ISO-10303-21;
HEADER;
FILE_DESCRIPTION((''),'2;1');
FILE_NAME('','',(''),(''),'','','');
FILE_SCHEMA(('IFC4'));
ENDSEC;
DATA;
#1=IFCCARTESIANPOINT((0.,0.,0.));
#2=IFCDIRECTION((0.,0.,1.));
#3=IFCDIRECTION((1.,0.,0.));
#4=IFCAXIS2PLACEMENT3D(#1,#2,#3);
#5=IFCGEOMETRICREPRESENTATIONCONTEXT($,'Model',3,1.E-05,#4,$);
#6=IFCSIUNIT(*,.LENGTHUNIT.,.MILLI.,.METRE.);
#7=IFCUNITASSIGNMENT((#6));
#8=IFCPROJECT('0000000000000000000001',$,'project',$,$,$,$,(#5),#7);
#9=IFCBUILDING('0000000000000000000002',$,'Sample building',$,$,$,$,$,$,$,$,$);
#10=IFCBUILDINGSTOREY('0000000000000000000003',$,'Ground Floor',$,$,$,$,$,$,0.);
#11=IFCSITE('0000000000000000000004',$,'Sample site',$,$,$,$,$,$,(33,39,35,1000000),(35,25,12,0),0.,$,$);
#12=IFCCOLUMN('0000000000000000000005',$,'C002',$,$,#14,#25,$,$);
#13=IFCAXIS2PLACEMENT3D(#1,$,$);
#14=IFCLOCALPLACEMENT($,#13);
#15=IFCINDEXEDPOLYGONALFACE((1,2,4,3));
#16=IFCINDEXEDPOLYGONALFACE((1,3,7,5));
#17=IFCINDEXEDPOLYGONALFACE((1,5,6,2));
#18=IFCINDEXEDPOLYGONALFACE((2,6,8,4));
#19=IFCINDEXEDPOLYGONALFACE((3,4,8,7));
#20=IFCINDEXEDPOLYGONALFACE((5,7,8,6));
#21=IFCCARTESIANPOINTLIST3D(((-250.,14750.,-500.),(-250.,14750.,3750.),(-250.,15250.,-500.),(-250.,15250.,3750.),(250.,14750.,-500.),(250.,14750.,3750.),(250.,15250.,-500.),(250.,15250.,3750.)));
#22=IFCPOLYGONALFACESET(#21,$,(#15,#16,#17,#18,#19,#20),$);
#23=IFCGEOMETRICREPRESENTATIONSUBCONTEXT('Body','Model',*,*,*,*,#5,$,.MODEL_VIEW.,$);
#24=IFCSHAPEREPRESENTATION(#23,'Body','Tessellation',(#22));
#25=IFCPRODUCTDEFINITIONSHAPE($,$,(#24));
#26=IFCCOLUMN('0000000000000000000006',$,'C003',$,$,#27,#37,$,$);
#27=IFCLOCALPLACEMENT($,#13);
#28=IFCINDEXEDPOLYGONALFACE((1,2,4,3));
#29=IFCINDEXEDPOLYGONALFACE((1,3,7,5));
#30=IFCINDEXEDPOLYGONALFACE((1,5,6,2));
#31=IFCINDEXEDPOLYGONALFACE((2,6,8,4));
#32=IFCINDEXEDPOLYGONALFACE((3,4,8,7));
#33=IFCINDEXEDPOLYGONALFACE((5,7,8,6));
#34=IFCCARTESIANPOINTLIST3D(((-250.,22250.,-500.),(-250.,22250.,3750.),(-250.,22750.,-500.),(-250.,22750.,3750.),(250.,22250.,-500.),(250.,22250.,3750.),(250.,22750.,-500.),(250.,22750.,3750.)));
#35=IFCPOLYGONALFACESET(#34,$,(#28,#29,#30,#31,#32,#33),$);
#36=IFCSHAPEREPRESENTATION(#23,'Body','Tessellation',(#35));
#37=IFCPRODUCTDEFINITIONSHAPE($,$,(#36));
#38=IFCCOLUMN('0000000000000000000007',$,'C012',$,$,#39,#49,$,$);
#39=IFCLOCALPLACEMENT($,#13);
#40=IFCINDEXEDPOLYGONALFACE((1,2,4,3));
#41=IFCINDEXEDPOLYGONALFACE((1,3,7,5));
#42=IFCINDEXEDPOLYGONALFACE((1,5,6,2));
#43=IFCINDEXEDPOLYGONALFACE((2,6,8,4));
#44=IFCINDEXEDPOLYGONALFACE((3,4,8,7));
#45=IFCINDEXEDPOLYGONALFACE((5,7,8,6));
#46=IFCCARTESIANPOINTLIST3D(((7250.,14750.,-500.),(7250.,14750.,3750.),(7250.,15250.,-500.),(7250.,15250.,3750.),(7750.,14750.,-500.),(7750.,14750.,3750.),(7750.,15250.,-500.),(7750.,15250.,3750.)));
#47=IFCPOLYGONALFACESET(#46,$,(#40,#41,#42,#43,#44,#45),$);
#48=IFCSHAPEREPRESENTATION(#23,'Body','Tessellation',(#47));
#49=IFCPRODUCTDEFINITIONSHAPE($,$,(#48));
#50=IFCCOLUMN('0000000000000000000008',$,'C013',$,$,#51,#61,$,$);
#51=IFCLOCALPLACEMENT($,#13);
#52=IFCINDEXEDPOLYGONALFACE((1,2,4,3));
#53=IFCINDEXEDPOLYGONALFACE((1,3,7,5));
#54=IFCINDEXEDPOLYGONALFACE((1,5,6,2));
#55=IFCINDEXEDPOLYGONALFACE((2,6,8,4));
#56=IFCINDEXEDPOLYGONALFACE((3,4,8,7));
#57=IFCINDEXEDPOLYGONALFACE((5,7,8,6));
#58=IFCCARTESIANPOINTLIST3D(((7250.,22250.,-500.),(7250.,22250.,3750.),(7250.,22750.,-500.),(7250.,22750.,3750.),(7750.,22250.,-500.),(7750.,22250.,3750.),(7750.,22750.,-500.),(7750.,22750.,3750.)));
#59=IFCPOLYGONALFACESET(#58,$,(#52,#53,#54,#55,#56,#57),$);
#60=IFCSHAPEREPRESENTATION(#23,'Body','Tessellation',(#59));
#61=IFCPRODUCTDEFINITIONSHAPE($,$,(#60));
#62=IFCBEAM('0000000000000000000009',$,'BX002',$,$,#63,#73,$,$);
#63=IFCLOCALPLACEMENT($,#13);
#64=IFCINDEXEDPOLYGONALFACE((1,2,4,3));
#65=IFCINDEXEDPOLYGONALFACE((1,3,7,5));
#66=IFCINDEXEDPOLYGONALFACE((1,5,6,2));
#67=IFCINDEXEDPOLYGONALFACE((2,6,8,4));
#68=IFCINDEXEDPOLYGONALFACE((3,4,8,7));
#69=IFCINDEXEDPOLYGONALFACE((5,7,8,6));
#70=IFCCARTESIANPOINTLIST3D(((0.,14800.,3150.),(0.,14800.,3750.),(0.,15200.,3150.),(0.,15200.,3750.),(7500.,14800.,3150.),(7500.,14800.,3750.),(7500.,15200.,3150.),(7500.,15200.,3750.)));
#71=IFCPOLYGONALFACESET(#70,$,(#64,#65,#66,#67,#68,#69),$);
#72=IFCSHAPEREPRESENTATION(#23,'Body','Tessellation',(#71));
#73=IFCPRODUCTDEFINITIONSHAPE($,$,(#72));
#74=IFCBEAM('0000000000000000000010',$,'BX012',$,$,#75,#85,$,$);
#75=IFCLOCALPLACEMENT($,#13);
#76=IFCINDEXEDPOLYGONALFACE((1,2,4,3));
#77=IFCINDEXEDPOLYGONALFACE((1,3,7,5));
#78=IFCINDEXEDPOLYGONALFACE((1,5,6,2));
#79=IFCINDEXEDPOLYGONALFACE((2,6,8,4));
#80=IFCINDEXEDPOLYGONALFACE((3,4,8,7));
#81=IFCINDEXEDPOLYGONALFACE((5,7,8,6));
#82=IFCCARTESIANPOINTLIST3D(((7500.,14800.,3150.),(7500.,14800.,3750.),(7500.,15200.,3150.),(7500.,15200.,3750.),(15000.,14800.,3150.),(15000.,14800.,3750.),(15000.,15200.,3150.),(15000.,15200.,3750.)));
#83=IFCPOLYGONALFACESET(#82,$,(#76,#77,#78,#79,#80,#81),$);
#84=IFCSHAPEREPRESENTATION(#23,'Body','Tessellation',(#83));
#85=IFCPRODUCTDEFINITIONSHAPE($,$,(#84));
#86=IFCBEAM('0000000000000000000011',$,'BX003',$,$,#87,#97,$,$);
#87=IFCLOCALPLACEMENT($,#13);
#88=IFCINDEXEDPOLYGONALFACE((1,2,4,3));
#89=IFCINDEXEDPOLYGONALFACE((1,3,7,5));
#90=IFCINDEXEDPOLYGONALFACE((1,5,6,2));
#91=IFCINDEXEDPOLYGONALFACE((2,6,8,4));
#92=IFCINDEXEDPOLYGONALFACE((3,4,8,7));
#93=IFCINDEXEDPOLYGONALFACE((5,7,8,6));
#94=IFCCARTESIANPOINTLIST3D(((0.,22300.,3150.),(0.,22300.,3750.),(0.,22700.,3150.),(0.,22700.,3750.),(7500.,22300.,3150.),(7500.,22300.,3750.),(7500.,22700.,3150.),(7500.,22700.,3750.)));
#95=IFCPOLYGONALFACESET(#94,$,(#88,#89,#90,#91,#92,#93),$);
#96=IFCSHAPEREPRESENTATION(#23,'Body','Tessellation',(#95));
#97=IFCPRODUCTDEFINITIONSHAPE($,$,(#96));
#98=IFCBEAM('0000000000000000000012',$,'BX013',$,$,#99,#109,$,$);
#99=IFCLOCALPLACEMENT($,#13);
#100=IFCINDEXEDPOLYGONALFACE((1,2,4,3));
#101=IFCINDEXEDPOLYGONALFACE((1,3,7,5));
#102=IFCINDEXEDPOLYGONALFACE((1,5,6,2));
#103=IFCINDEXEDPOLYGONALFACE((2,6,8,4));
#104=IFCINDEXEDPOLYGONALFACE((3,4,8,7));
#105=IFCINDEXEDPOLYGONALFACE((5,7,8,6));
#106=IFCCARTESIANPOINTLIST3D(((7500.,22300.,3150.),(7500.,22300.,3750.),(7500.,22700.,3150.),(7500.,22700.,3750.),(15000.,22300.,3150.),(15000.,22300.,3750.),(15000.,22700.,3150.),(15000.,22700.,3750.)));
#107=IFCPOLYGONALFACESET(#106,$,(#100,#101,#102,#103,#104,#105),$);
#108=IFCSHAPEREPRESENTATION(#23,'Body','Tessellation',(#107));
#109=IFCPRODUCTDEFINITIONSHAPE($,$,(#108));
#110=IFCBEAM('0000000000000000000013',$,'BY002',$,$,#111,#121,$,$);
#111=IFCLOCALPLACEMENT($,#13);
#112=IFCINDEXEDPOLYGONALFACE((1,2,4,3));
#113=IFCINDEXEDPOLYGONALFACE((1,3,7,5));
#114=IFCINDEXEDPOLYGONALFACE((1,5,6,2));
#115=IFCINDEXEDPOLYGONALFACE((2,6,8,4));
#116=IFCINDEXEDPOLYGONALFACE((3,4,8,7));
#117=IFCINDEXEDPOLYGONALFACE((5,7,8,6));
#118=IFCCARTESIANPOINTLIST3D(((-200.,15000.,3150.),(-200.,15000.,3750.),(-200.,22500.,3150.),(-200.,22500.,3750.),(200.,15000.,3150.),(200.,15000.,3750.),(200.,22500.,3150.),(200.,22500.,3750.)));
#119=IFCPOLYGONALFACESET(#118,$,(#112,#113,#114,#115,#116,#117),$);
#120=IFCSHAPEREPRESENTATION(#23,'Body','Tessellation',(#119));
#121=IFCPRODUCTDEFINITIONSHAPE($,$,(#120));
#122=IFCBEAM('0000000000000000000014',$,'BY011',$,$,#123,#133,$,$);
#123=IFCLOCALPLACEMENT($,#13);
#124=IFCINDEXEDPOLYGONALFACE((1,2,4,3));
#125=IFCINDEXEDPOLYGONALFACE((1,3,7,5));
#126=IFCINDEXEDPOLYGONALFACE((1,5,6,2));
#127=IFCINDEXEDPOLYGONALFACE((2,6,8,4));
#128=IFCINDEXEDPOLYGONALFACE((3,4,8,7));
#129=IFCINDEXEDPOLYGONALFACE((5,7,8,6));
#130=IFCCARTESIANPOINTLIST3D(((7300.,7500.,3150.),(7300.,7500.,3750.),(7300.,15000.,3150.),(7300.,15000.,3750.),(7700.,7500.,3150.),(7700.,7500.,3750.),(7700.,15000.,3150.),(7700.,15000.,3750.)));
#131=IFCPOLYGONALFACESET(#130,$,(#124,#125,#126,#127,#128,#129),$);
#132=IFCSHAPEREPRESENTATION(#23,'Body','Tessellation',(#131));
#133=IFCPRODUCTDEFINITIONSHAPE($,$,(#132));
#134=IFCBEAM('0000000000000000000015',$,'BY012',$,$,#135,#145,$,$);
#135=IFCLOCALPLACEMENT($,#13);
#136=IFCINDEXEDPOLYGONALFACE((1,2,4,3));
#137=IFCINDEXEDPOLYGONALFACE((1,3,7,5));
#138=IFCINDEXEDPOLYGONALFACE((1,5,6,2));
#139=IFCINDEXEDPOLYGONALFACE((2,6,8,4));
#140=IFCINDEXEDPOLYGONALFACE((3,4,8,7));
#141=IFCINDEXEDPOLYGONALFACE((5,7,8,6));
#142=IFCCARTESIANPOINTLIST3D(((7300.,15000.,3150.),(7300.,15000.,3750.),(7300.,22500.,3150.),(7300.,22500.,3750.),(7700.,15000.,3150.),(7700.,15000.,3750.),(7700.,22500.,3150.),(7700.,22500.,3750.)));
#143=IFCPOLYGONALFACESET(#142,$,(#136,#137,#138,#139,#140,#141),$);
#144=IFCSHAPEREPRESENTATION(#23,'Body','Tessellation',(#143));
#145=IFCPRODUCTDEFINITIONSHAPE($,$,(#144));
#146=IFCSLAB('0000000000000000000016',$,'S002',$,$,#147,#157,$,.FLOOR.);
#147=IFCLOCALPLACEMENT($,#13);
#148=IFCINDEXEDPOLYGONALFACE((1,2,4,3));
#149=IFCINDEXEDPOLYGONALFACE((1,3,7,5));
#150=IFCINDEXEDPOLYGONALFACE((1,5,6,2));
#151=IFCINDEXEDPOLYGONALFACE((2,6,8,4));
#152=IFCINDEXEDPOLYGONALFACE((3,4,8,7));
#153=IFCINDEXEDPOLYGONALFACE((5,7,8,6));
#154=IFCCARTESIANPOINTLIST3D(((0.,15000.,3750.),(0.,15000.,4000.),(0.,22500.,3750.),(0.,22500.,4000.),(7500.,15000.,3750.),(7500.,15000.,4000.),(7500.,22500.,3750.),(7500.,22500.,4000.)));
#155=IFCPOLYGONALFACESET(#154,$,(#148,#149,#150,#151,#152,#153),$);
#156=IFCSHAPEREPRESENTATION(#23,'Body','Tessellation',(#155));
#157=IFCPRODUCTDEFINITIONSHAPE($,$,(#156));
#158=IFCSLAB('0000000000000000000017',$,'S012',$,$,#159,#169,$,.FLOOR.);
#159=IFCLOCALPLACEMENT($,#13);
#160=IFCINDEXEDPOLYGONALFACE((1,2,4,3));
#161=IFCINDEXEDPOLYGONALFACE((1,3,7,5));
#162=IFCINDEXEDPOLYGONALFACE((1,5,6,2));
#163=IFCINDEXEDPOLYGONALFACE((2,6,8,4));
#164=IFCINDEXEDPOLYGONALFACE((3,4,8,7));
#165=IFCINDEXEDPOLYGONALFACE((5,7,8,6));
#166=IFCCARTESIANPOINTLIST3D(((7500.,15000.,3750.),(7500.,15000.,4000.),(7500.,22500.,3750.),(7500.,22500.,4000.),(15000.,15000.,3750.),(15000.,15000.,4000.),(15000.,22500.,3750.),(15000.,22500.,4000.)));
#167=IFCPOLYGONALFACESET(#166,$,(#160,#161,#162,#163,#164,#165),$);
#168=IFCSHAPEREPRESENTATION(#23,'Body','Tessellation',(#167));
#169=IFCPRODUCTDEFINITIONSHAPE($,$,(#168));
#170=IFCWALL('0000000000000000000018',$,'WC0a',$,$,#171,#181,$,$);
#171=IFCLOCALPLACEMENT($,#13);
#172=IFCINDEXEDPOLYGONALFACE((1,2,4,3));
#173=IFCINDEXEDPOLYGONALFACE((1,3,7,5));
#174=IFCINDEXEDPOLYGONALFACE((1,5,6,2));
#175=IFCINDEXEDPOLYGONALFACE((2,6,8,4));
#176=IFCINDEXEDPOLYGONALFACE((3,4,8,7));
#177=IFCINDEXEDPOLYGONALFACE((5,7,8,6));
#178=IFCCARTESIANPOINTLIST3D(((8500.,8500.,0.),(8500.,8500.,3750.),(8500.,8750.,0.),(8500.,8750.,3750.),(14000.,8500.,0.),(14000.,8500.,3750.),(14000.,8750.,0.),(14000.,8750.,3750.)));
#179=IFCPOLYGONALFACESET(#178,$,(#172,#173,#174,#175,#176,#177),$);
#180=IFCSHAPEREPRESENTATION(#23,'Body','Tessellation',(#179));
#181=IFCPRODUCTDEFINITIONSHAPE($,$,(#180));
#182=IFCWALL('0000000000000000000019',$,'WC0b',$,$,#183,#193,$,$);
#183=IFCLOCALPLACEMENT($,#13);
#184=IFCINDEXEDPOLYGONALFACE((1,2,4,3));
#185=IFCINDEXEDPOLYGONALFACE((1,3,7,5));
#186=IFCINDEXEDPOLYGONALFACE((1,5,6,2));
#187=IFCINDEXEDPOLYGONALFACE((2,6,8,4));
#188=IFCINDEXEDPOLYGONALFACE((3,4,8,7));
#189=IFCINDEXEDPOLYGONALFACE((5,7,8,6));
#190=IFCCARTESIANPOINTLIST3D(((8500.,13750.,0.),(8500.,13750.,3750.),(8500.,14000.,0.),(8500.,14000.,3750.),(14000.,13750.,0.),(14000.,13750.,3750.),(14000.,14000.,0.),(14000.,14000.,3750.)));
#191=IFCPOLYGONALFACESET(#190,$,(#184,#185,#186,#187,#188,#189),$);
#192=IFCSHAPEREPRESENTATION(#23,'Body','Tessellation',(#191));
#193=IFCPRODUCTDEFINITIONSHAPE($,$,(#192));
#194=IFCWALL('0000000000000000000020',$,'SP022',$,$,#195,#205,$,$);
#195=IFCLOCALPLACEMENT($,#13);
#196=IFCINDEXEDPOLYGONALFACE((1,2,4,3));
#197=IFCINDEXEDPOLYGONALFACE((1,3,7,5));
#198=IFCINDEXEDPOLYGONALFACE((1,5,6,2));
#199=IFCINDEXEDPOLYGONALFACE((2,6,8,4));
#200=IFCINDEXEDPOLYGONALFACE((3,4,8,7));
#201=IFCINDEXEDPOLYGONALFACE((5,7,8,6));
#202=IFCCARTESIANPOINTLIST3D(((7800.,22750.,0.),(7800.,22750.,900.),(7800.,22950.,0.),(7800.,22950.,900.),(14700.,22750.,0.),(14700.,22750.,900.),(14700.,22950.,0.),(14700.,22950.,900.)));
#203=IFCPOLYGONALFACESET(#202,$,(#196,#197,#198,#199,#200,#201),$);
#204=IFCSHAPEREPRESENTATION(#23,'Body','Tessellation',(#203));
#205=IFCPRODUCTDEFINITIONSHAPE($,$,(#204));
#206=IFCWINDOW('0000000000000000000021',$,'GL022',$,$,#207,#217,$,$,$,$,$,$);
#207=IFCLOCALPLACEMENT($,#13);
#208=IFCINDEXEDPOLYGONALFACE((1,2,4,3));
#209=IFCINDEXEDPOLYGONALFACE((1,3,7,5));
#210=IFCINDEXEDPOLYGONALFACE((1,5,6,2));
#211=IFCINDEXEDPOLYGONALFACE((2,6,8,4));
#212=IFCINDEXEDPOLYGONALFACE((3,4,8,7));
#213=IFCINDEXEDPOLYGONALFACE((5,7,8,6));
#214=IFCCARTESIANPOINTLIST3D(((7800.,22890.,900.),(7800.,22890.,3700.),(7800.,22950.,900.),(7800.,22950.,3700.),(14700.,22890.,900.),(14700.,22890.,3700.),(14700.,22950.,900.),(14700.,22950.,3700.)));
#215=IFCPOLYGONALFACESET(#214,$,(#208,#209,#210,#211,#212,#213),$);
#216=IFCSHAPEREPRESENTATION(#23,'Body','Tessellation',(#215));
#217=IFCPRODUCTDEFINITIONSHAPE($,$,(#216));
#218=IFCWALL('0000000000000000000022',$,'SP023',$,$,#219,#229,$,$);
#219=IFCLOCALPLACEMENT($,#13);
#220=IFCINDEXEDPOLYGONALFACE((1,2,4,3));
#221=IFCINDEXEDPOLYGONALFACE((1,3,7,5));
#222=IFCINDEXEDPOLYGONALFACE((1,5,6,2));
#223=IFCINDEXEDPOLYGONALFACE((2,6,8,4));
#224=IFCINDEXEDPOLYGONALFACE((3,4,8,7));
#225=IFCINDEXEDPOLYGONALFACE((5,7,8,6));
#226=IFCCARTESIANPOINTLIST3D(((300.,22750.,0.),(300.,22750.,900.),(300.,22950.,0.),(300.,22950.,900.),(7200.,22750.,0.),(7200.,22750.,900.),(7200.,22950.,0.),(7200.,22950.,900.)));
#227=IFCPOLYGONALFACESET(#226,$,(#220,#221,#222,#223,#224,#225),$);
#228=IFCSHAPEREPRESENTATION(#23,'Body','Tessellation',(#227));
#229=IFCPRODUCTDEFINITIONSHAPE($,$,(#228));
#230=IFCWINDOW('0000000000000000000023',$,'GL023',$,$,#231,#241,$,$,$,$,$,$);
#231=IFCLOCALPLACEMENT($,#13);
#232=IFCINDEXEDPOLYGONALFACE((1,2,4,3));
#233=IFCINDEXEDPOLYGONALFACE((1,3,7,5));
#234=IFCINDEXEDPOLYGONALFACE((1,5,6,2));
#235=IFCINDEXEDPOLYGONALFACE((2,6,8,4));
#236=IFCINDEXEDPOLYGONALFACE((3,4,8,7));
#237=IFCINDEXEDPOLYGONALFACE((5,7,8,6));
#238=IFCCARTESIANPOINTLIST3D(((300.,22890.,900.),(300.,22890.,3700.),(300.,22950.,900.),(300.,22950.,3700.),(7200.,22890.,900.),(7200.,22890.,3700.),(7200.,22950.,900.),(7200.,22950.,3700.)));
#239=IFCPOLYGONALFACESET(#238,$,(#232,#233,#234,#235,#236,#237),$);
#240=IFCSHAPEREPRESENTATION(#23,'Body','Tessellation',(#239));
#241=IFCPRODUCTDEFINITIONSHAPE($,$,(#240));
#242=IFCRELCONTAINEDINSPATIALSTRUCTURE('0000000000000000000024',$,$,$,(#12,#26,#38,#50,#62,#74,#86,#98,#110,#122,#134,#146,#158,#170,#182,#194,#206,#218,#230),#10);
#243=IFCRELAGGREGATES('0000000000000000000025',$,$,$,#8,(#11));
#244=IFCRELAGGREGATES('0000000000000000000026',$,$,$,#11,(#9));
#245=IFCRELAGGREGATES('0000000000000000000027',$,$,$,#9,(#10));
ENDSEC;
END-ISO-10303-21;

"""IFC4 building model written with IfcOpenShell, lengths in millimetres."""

from ifc_helpers import new_model, si_unit, frame, origin_with_axes, place, context, subcontext, project, spatial, indexed_curve, outline, extrude, element, save


model = new_model("IFC4")

# Units and contexts
model_context = context("Model", 3, precision=1e-05, world=origin_with_axes())
body_context = subcontext(model_context, "Body", "Model", "MODEL_VIEW")
ifc_project = project(units=[si_unit("LENGTHUNIT", "METRE", prefix="MILLI")], contexts=[model_context])

# Site, building, storey
site = spatial("IfcSite", under=ifc_project, Name="Sample site", RefLatitude=(33, 39, 35, 1000000), RefLongitude=(35, 25, 12, 0), RefElevation=0.0)
building = spatial("IfcBuilding", under=site, Name="Sample building")
storey = spatial("IfcBuildingStorey", under=building, Name="Ground Floor", Elevation=0.0)

# Columns
for number, where, z_axis, x_axis, name in (
    (1, (-250.0, 14750.0, -500.0), (0.0, 0.0, 1.0), (1.0, 0.0, 0.0), "C002"),
    (2, (-250.0, 22250.0, -500.0), (0.0, 0.0, 1.0), (1.0, 0.0, 0.0), "C003"),
    (3, (7250.0, 14750.0, -500.0), (0.0, 0.0, 1.0), (1.0, 0.0, 0.0), "C012"),
    (4, (7250.0, 22250.0, -500.0), (0.0, 0.0, 1.0), (1.0, 0.0, 0.0), "C013"),
):
    element("IfcColumn", number, at=place(None, frame(where, z_axis=z_axis, x_axis=x_axis)), inside=storey, Name=name, context=body_context, shape_type="SweptSolid", body=[
        extrude(outline(indexed_curve([(0.0, 0.0), (0.0, 500.0), (500.0, 500.0), (500.0, 0.0), (0.0, 0.0)], self_intersect=False)), origin_with_axes(), (0.0, 0.0, 1.0), 4250.0),
    ])

# Beams
for number, where, z_axis, x_axis, name in (
    (5, (0.0, 14800.0, 3150.0), (0.0, 0.0, 1.0), (1.0, 0.0, 0.0), "BX002"),
    (6, (7500.0, 14800.0, 3150.0), (0.0, 0.0, 1.0), (1.0, 0.0, 0.0), "BX012"),
    (7, (0.0, 22300.0, 3150.0), (0.0, 0.0, 1.0), (1.0, 0.0, 0.0), "BX003"),
    (8, (7500.0, 22300.0, 3150.0), (0.0, 0.0, 1.0), (1.0, 0.0, 0.0), "BX013"),
    (9, (200.0, 15000.0, 3150.0), (0.0, 0.0, 1.0), (0.0, 1.0, 0.0), "BY002"),
    (10, (7700.0, 7500.0, 3150.0), (0.0, 0.0, 1.0), (0.0, 1.0, 0.0), "BY011"),
    (11, (7700.0, 15000.0, 3150.0), (0.0, 0.0, 1.0), (0.0, 1.0, 0.0), "BY012"),
):
    element("IfcBeam", number, at=place(None, frame(where, z_axis=z_axis, x_axis=x_axis)), inside=storey, Name=name, context=body_context, shape_type="SweptSolid", body=[
        extrude(outline(indexed_curve([(0.0, 0.0), (0.0, 400.0), (7500.0, 400.0), (7500.0, 0.0), (0.0, 0.0)], self_intersect=False)), origin_with_axes(), (0.0, 0.0, 1.0), 600.0),
    ])

# Slabs
for number, where, z_axis, x_axis, name in (
    (12, (0.0, 15000.0, 3750.0), (0.0, 0.0, 1.0), (1.0, 0.0, 0.0), "S002"),
    (13, (7500.0, 15000.0, 3750.0), (0.0, 0.0, 1.0), (1.0, 0.0, 0.0), "S012"),
):
    element("IfcSlab", number, at=place(None, frame(where, z_axis=z_axis, x_axis=x_axis)), inside=storey, Name=name, PredefinedType="FLOOR", context=body_context, shape_type="SweptSolid", body=[
        extrude(outline(indexed_curve([(0.0, 0.0), (0.0, 7500.0), (7500.0, 7500.0), (7500.0, 0.0), (0.0, 0.0)], self_intersect=False)), origin_with_axes(), (0.0, 0.0, 1.0), 250.0),
    ])

# Walls
for number, where, z_axis, x_axis, name in (
    (14, (8500.0, 8500.0, 0.0), (0.0, 0.0, 1.0), (1.0, 0.0, 0.0), "WC0a"),
    (15, (8500.0, 13750.0, 0.0), (0.0, 0.0, 1.0), (1.0, 0.0, 0.0), "WC0b"),
):
    element("IfcWall", number, at=place(None, frame(where, z_axis=z_axis, x_axis=x_axis)), inside=storey, Name=name, context=body_context, shape_type="SweptSolid", body=[
        extrude(outline(indexed_curve([(0.0, 0.0), (0.0, 250.0), (5500.0, 250.0), (5500.0, 0.0), (0.0, 0.0)], self_intersect=False)), origin_with_axes(), (0.0, 0.0, 1.0), 3750.0),
    ])
wall_1_placement = place(None, frame((14700.0, 22950.0, 0.0), z_axis=(0.0, 0.0, 1.0), x_axis=(-1.0, 0.0, 0.0)))
element("IfcWall", 16, at=wall_1_placement, inside=storey, Name="SP022", context=body_context, shape_type="SweptSolid", body=[
    extrude(outline(indexed_curve([(0.0, 0.0), (0.0, 200.0), (6900.0, 200.0), (6900.0, 0.0), (0.0, 0.0)], self_intersect=False)), origin_with_axes(), (0.0, 0.0, 1.0), 900.0),
])

# Window
window_1_placement = place(None, frame((14700.0, 22950.0, 900.0), z_axis=(0.0, 0.0, 1.0), x_axis=(-1.0, 0.0, 0.0)))
element("IfcWindow", 17, at=window_1_placement, inside=storey, Name="GL022", context=body_context, shape_type="SweptSolid", body=[
    extrude(outline(indexed_curve([(0.0, 0.0), (0.0, 60.0), (6900.0, 60.0), (6900.0, 0.0), (0.0, 0.0)], self_intersect=False)), origin_with_axes(), (0.0, 0.0, 1.0), 2800.0),
])

# Wall
wall_2_placement = place(None, frame((7200.0, 22950.0, 0.0), z_axis=(0.0, 0.0, 1.0), x_axis=(-1.0, 0.0, 0.0)))
element("IfcWall", 18, at=wall_2_placement, inside=storey, Name="SP023", context=body_context, shape_type="SweptSolid", body=[
    extrude(outline(indexed_curve([(0.0, 0.0), (0.0, 200.0), (6900.0, 200.0), (6900.0, 0.0), (0.0, 0.0)], self_intersect=False)), origin_with_axes(), (0.0, 0.0, 1.0), 900.0),
])

# Window
window_2_placement = place(None, frame((7200.0, 22950.0, 900.0), z_axis=(0.0, 0.0, 1.0), x_axis=(-1.0, 0.0, 0.0)))
element("IfcWindow", 19, at=window_2_placement, inside=storey, Name="GL023", context=body_context, shape_type="SweptSolid", body=[
    extrude(outline(indexed_curve([(0.0, 0.0), (0.0, 60.0), (6900.0, 60.0), (6900.0, 0.0), (0.0, 0.0)], self_intersect=False)), origin_with_axes(), (0.0, 0.0, 1.0), 2800.0),
])

save(model, "model.ifc")
